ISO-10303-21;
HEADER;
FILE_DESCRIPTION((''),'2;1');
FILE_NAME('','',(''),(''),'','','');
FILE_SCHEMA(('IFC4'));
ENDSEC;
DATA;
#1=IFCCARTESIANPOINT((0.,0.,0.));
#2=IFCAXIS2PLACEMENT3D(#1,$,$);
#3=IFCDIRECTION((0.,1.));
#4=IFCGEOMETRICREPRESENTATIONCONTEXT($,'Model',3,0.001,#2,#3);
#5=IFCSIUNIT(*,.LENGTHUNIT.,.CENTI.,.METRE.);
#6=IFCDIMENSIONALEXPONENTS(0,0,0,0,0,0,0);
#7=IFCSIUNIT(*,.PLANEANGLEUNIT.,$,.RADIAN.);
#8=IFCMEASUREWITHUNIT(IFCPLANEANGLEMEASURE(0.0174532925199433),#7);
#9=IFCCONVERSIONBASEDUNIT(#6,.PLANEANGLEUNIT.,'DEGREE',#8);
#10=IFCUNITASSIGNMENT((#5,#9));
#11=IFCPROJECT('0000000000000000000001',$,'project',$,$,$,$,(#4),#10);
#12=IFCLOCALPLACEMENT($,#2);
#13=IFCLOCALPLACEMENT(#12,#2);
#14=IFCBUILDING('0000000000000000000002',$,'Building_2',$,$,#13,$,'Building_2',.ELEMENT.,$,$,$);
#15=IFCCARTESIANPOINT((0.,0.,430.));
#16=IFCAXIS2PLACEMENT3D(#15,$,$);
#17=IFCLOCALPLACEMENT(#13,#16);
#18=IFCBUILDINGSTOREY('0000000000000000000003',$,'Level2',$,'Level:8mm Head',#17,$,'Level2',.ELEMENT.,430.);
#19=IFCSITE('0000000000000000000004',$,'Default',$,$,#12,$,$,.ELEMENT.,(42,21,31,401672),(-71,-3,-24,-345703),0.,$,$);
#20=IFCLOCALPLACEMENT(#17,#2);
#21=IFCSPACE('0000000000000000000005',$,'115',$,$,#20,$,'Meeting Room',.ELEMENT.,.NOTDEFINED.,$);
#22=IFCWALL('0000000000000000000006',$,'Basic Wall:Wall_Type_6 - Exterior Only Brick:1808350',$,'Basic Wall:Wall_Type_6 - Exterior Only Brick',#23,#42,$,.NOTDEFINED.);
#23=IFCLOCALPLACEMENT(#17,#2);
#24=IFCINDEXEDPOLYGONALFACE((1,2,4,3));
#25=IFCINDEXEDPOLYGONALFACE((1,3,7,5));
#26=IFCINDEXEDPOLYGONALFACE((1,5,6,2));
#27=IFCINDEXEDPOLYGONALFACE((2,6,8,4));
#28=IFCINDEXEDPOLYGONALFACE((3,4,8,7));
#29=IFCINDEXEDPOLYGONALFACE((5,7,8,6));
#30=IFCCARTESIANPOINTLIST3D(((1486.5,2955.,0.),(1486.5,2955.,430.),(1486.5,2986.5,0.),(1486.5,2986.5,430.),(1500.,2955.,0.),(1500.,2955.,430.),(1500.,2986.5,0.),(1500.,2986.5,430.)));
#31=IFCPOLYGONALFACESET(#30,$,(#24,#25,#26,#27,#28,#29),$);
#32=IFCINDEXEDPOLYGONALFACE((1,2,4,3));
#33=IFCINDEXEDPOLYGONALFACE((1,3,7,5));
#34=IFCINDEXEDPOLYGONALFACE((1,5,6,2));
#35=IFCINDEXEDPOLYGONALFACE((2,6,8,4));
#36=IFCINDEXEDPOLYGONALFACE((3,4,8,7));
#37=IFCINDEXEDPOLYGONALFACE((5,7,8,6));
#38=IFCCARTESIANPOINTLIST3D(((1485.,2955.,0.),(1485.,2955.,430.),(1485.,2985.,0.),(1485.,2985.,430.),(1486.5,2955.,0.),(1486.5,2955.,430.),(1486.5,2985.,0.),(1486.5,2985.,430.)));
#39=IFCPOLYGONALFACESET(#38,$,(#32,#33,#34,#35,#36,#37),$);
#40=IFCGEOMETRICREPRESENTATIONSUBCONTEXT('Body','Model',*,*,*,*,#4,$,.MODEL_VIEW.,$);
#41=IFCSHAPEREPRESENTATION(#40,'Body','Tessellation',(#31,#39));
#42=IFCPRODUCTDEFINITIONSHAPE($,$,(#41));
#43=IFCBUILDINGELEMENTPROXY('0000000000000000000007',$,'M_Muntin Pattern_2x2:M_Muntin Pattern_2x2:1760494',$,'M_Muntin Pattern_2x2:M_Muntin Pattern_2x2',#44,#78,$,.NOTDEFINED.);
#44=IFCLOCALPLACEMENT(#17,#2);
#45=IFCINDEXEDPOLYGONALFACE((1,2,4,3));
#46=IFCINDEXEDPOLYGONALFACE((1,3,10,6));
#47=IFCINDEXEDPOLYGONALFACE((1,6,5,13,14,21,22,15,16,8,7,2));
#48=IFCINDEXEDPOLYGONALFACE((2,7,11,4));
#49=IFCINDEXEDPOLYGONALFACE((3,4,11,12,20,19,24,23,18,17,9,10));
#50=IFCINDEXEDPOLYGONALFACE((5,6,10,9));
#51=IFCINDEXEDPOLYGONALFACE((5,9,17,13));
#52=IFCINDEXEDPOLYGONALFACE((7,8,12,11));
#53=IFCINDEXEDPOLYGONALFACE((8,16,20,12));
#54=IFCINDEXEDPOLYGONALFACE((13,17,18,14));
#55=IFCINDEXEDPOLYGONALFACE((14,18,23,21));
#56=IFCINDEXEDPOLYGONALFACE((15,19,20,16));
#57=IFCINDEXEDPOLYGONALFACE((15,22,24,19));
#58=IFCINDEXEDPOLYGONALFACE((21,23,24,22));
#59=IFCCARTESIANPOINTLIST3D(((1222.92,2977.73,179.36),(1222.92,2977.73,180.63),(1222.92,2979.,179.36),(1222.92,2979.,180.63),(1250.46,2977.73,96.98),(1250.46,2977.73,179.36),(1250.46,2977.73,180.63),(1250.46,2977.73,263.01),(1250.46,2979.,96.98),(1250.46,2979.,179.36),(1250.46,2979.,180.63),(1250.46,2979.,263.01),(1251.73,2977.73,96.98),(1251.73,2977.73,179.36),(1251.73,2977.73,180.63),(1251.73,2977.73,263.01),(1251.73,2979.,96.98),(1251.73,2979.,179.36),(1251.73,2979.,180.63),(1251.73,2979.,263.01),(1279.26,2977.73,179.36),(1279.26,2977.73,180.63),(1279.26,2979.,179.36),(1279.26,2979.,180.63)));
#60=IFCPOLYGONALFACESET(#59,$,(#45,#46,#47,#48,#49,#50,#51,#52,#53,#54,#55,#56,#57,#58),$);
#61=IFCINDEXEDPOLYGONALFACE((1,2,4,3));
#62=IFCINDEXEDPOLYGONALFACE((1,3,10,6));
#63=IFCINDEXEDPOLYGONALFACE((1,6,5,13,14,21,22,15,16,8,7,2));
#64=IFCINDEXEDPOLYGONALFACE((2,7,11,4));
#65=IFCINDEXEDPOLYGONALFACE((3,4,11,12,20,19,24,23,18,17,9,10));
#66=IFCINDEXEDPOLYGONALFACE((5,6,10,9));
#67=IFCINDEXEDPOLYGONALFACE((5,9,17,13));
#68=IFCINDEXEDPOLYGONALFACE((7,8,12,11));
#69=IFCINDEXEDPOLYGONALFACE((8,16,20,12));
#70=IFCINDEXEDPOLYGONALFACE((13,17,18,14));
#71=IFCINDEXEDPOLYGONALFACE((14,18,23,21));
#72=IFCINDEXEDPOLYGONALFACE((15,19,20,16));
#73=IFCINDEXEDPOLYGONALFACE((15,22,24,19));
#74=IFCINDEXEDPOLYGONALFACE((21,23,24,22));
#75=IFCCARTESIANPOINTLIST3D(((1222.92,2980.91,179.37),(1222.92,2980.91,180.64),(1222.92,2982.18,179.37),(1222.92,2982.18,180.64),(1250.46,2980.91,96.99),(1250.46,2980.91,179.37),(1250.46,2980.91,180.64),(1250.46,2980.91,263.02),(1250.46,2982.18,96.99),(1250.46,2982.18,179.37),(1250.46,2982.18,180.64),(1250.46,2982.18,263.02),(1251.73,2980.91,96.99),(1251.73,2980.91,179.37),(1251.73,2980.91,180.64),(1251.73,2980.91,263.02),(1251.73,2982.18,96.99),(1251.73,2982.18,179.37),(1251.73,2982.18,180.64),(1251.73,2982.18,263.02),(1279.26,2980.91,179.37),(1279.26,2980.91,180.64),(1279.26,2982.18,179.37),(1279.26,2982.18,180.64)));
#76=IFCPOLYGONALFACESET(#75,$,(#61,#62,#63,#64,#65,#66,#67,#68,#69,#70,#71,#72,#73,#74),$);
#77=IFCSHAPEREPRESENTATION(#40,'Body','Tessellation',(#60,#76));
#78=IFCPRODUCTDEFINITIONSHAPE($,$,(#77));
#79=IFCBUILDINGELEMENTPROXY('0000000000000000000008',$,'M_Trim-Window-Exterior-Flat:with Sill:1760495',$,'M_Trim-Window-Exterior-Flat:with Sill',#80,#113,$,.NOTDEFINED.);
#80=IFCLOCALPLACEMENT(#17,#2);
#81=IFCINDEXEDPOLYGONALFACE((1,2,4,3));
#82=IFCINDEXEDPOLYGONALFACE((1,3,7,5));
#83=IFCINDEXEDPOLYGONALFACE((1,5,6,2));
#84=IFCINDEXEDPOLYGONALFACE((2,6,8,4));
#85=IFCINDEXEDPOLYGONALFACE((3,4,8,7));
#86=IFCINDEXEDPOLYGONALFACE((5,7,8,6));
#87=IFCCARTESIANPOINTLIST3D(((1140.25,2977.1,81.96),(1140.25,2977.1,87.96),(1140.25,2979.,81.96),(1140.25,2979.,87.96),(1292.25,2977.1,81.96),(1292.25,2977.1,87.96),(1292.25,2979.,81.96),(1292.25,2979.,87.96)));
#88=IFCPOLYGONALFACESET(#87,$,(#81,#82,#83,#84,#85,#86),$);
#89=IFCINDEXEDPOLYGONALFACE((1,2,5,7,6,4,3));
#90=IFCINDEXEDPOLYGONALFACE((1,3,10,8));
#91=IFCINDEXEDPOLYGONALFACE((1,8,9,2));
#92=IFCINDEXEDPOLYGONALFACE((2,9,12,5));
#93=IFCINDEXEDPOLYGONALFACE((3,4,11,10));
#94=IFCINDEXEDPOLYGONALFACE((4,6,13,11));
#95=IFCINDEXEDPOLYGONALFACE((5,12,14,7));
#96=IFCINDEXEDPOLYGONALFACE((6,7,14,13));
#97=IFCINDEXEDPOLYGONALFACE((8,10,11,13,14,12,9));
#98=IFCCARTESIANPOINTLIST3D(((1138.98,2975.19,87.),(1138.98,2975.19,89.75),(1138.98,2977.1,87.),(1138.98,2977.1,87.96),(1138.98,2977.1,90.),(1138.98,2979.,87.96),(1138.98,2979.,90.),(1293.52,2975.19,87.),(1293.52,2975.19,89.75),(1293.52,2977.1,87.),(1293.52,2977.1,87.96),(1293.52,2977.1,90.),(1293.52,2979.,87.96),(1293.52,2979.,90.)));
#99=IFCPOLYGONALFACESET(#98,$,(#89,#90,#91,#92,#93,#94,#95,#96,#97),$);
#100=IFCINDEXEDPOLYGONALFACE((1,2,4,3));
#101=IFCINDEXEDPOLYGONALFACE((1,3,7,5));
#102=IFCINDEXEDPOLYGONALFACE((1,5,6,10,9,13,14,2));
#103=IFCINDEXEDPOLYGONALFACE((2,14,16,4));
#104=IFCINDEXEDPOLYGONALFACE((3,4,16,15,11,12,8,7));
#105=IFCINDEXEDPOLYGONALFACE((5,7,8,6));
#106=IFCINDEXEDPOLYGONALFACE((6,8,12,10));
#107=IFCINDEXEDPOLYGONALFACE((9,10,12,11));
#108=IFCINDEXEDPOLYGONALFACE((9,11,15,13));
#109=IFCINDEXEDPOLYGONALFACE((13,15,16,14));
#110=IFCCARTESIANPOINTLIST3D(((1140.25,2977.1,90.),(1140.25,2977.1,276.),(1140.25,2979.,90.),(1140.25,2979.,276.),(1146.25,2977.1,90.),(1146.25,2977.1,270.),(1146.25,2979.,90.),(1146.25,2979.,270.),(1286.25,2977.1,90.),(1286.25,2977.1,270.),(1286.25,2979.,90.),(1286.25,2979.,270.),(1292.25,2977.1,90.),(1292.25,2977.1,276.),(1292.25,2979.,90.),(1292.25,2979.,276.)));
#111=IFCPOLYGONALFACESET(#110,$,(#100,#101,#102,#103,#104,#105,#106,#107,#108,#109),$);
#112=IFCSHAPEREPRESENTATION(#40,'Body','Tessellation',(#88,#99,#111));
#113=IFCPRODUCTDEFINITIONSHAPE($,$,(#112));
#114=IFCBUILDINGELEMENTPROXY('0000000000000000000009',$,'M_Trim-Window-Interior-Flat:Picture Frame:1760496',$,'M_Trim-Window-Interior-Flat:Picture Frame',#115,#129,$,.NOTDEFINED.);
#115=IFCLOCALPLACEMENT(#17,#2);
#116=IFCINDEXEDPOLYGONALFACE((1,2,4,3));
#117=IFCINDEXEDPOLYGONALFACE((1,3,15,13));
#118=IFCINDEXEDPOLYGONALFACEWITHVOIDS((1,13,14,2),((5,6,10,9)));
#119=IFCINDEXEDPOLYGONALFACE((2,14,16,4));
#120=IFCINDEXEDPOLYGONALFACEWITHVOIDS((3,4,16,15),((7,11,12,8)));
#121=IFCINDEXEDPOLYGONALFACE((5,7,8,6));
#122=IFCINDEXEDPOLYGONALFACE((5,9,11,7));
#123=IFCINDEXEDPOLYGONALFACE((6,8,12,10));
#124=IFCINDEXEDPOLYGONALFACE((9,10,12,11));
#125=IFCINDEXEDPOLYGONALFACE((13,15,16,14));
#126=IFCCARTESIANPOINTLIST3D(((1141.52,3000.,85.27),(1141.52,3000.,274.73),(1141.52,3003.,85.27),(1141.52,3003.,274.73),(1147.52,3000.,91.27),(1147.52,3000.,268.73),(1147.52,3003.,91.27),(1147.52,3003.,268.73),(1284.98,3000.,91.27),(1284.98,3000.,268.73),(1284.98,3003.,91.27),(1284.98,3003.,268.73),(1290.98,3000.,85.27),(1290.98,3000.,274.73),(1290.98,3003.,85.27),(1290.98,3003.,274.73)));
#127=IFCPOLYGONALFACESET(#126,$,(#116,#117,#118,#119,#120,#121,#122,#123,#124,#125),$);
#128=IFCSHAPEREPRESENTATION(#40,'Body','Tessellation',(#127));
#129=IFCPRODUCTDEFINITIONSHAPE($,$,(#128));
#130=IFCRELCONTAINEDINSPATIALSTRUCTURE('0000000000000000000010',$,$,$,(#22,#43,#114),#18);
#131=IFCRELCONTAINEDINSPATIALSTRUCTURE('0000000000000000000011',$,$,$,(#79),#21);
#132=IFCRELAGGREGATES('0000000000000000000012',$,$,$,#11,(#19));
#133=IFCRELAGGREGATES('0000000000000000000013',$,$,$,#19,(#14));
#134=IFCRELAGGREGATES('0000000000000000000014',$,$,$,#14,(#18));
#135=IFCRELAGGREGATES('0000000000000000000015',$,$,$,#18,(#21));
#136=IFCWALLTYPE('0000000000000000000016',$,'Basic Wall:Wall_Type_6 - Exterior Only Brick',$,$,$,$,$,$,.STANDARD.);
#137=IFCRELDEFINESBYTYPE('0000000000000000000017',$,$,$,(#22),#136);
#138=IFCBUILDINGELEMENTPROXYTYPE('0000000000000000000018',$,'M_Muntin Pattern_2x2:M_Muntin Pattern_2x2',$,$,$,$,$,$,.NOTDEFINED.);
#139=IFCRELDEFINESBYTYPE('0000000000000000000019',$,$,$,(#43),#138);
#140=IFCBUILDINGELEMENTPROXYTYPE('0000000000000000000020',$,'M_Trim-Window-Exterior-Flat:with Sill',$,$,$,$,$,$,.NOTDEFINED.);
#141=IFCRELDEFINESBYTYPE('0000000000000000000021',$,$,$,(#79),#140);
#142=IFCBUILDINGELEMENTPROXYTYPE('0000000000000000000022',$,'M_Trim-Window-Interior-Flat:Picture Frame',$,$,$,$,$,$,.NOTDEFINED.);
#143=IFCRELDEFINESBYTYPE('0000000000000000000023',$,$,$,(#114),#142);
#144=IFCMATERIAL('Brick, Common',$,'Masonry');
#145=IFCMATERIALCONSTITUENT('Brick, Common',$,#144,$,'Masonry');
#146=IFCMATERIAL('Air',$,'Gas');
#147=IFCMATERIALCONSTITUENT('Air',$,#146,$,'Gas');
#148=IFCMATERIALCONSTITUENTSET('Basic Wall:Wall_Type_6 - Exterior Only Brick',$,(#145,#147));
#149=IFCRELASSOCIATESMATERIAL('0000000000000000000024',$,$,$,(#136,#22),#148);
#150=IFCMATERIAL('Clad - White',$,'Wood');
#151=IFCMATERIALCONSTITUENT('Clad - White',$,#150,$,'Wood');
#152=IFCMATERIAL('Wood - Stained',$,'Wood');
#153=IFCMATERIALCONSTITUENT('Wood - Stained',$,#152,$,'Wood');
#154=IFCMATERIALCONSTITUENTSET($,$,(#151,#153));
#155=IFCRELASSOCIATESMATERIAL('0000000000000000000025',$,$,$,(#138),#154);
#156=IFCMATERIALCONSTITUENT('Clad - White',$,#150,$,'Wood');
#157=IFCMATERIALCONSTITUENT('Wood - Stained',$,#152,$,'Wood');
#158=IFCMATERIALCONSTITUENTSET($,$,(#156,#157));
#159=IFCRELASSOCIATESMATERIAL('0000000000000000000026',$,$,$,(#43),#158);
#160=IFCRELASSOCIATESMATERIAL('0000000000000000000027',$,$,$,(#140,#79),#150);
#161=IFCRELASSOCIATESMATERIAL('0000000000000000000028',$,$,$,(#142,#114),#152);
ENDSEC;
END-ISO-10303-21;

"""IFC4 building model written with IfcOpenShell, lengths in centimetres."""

from ifc_helpers import new_model, entity, si_unit, converted_unit, direction, frame, origin, place, context, subcontext, project, spatial, indexed_curve, outline, extrude, source, transform, mapped, material, constituent, constituent_set, type_object, type_shapes, element, save


model = new_model("IFC4")

# Units and contexts
model_context = context("Model", 3, precision=0.001, world=origin(), true_north=direction((0.0, 1.0)))
body_context = subcontext(model_context, "Body", "Model", "MODEL_VIEW")
ifc_project = project(units=[si_unit("LENGTHUNIT", "METRE", prefix="CENTI"), converted_unit("PLANEANGLEUNIT", "DEGREE", entity("IfcPlaneAngleMeasure", 0.0174532925199433), si_unit("PLANEANGLEUNIT", "RADIAN"), dimensions=[0, 0, 0, 0, 0, 0, 0])], contexts=[model_context])

# Site, building, storey
site_placement = place(None, origin())
site = spatial("IfcSite", under=ifc_project, at=site_placement, Name="Default", CompositionType="ELEMENT", RefLatitude=(42, 21, 31, 401672), RefLongitude=(-71, -3, -24, -345703), RefElevation=0.0)
building_placement = place(site_placement, origin())
building = spatial("IfcBuilding", under=site, at=building_placement, Name="Building_2", LongName="Building_2", CompositionType="ELEMENT")
storey_placement = place(building_placement, frame((0.0, 0.0, 430.0)))
storey = spatial("IfcBuildingStorey", under=building, at=storey_placement, Name="Level2", ObjectType="Level:8mm Head", LongName="Level2", CompositionType="ELEMENT", Elevation=430.0)

# Wall
ifc_material_1 = material(Name="Brick, Common", Category="Masonry")
ifc_constituent_1 = constituent(ifc_material_1, Name="Brick, Common", Category="Masonry")
ifc_material_2 = material(Name="Air", Category="Gas")
ifc_constituent_2 = constituent(ifc_material_2, Name="Air", Category="Gas")
ifc_constituent_set_1 = constituent_set(constituents=[ifc_constituent_1, ifc_constituent_2], Name="Basic Wall:Wall_Type_6 - Exterior Only Brick")
wall_type = type_object("IfcWallType", Name="Basic Wall:Wall_Type_6 - Exterior Only Brick", PredefinedType="STANDARD", material=ifc_constituent_set_1)
wall_1_placement = place(storey_placement, frame((1492.5, 2985.0, 0.0), z_axis=(0.0, 0.0, 1.0), x_axis=(0.0, -1.0, 0.0)))
element("IfcWall", 1, at=wall_1_placement, inside=storey, type_object=wall_type, material=ifc_constituent_set_1, Name="Basic Wall:Wall_Type_6 - Exterior Only Brick:1808350", ObjectType="Basic Wall:Wall_Type_6 - Exterior Only Brick", PredefinedType="NOTDEFINED", context=body_context, shape_type="SweptSolid", body=[
    extrude(outline(indexed_curve([(-6.75, -15.75), (6.75, -15.75), (6.75, 15.75), (-6.75, 15.75), (-6.75, -15.75)], self_intersect=False)), frame((14.25, 0.75, 0.0), z_axis=(0.0, 0.0, 1.0), x_axis=(0.0, -1.0, 0.0)), (0.0, 0.0, 1.0), 430.0),
    extrude(outline(indexed_curve([(-0.75, -15.0), (0.75, -15.0), (0.75, 15.0), (-0.75, 15.0), (-0.75, -15.0)], self_intersect=False)), frame((15.0, -6.75, 0.0), z_axis=(0.0, 0.0, 1.0), x_axis=(0.0, 1.0, 0.0)), (0.0, 0.0, 1.0), 430.0),
])

# Building element proxy
ifc_material_3 = material(Name="Clad - White", Category="Wood")
ifc_constituent_3 = constituent(ifc_material_3, Name="Clad - White", Category="Wood")
ifc_material_4 = material(Name="Wood - Stained", Category="Wood")
ifc_constituent_4 = constituent(ifc_material_4, Name="Wood - Stained", Category="Wood")
ifc_constituent_set_2 = constituent_set(constituents=[ifc_constituent_3, ifc_constituent_4])
ifc_constituent_5 = constituent(ifc_material_3, Name="Clad - White", Category="Wood")
ifc_constituent_6 = constituent(ifc_material_4, Name="Wood - Stained", Category="Wood")
ifc_constituent_set_3 = constituent_set(constituents=[ifc_constituent_5, ifc_constituent_6])
building_element_proxy_type_1 = type_object("IfcBuildingElementProxyType", Name="M_Muntin Pattern_2x2:M_Muntin Pattern_2x2", PredefinedType="NOTDEFINED", material=ifc_constituent_set_3)
shared_shape_1 = source(origin(), body_context, "Body", "SweptSolid", [
    extrude(outline(indexed_curve([(0.64, -0.64), (83.01, -0.64), (83.01, 0.63), (0.64, 0.63), (0.64, 28.17), (-0.63, 28.17), (-0.63, 0.63), (-83.02, 0.63), (-83.02, -0.64), (-0.63, -0.64), (-0.63, -28.17), (0.64, -28.17), (0.64, -0.64)], self_intersect=False)), frame((0.0, 0.95, 83.01), z_axis=(0.0, 1.0, 0.0), x_axis=(0.0, 0.0, 1.0)), (0.0, 0.0, 1.0), 1.27),
    extrude(outline(indexed_curve([(0.64, -0.64), (83.02, -0.64), (83.02, 0.63), (0.64, 0.63), (0.64, 28.17), (-0.63, 28.17), (-0.63, 0.63), (-83.02, 0.63), (-83.02, -0.64), (-0.63, -0.64), (-0.63, -28.17), (0.64, -28.17), (0.64, -0.64)], self_intersect=False)), frame((0.0, -2.22, 83.02), z_axis=(0.0, 1.0, 0.0), x_axis=(0.0, 0.0, 1.0)), (0.0, 0.0, 1.0), 1.27),
])
type_shapes(building_element_proxy_type_1, [shared_shape_1])
proxy_1_placement = place(storey_placement, frame((1251.09, 2979.95, 96.99), z_axis=(0.0, 0.0, 1.0), x_axis=(-1.0, 0.0, 0.0)))
element("IfcBuildingElementProxy", 2, at=proxy_1_placement, inside=storey, type_object=building_element_proxy_type_1, material=ifc_constituent_set_2, Name="M_Muntin Pattern_2x2:M_Muntin Pattern_2x2:1760494", ObjectType="M_Muntin Pattern_2x2:M_Muntin Pattern_2x2", PredefinedType="NOTDEFINED", context=body_context, shape_type="MappedRepresentation", body=[
    mapped(shared_shape_1, transform((0.0, 0.0, 0.0), scale=1.0)),
])

# Shared definitions
space_placement = place(storey_placement, origin())
space = spatial("IfcSpace", under=storey, at=space_placement, Name="115", LongName="Meeting Room", CompositionType="ELEMENT", PredefinedType="NOTDEFINED")

# Building element proxies
building_element_proxy_type_2 = type_object("IfcBuildingElementProxyType", Name="M_Trim-Window-Exterior-Flat:with Sill", PredefinedType="NOTDEFINED", material=ifc_material_3)
shared_shape_2 = source(origin(), body_context, "Body", "SweptSolid", [
    extrude(outline(indexed_curve([(-3.0, -76.0), (3.0, -76.0), (3.0, 76.0), (-3.0, 76.0), (-3.0, -76.0)], self_intersect=False)), frame((0.0, 185.04, 0.0), z_axis=(0.0, 0.0, 1.0), x_axis=(0.0, 1.0, 0.0)), (0.0, 0.0, 1.0), 1.91),
    extrude(outline(indexed_curve([(-1.52, -1.9), (1.23, -1.9), (1.48, 0.0), (1.48, 1.9), (-0.57, 1.9), (-0.57, 0.0), (-1.52, 0.0), (-1.52, -1.9)], self_intersect=False)), frame((-77.27, 181.48, 1.9), z_axis=(1.0, 0.0, 0.0), x_axis=(0.0, -1.0, 0.0)), (0.0, 0.0, 1.0), 154.54),
    extrude(outline(indexed_curve([(-76.0, -94.5), (76.0, -94.5), (76.0, 91.5), (70.0, 91.5), (70.0, -88.5), (-70.0, -88.5), (-70.0, 91.5), (-76.0, 91.5), (-76.0, -94.5)], self_intersect=False)), frame((0.0, 88.5, 0.0)), (0.0, 0.0, 1.0), 1.91),
])
type_shapes(building_element_proxy_type_2, [shared_shape_2])
proxy_2_placement = place(space_placement, frame((1216.25, 2979.0, 270.0), z_axis=(0.0, -1.0, 0.0), x_axis=(-1.0, 0.0, 0.0)))
element("IfcBuildingElementProxy", 3, at=proxy_2_placement, inside=space, type_object=building_element_proxy_type_2, material=ifc_material_3, Name="M_Trim-Window-Exterior-Flat:with Sill:1760495", ObjectType="M_Trim-Window-Exterior-Flat:with Sill", PredefinedType="NOTDEFINED", context=body_context, shape_type="MappedRepresentation", body=[
    mapped(shared_shape_2, transform((0.0, 0.0, 0.0), scale=1.0)),
])
building_element_proxy_type_3 = type_object("IfcBuildingElementProxyType", Name="M_Trim-Window-Interior-Flat:Picture Frame", PredefinedType="NOTDEFINED", material=ifc_material_4)
shared_shape_3 = source(origin(), body_context, "Body", "SweptSolid", [
    extrude(outline(indexed_curve([(-94.73, -74.73), (94.73, -74.73), (94.73, 74.73), (-94.73, 74.73), (-94.73, -74.73)], self_intersect=False), holes=[indexed_curve([(-88.73, -68.73), (-88.73, 68.73), (88.73, 68.73), (88.73, -68.73), (-88.73, -68.73)], self_intersect=False)]), frame((0.0, 90.0, 0.0), z_axis=(0.0, 0.0, 1.0), x_axis=(0.0, 1.0, 0.0)), (0.0, 0.0, 1.0), 3.0),
])
type_shapes(building_element_proxy_type_3, [shared_shape_3])
proxy_3_placement = place(storey_placement, frame((1216.25, 3000.0, 270.0), z_axis=(0.0, 1.0, 0.0), x_axis=(1.0, 0.0, 0.0)))
element("IfcBuildingElementProxy", 4, at=proxy_3_placement, inside=storey, type_object=building_element_proxy_type_3, material=ifc_material_4, Name="M_Trim-Window-Interior-Flat:Picture Frame:1760496", ObjectType="M_Trim-Window-Interior-Flat:Picture Frame", PredefinedType="NOTDEFINED", context=body_context, shape_type="MappedRepresentation", body=[
    mapped(shared_shape_3, transform((0.0, 0.0, 0.0), scale=1.0)),
])

save(model, "model.ifc")
